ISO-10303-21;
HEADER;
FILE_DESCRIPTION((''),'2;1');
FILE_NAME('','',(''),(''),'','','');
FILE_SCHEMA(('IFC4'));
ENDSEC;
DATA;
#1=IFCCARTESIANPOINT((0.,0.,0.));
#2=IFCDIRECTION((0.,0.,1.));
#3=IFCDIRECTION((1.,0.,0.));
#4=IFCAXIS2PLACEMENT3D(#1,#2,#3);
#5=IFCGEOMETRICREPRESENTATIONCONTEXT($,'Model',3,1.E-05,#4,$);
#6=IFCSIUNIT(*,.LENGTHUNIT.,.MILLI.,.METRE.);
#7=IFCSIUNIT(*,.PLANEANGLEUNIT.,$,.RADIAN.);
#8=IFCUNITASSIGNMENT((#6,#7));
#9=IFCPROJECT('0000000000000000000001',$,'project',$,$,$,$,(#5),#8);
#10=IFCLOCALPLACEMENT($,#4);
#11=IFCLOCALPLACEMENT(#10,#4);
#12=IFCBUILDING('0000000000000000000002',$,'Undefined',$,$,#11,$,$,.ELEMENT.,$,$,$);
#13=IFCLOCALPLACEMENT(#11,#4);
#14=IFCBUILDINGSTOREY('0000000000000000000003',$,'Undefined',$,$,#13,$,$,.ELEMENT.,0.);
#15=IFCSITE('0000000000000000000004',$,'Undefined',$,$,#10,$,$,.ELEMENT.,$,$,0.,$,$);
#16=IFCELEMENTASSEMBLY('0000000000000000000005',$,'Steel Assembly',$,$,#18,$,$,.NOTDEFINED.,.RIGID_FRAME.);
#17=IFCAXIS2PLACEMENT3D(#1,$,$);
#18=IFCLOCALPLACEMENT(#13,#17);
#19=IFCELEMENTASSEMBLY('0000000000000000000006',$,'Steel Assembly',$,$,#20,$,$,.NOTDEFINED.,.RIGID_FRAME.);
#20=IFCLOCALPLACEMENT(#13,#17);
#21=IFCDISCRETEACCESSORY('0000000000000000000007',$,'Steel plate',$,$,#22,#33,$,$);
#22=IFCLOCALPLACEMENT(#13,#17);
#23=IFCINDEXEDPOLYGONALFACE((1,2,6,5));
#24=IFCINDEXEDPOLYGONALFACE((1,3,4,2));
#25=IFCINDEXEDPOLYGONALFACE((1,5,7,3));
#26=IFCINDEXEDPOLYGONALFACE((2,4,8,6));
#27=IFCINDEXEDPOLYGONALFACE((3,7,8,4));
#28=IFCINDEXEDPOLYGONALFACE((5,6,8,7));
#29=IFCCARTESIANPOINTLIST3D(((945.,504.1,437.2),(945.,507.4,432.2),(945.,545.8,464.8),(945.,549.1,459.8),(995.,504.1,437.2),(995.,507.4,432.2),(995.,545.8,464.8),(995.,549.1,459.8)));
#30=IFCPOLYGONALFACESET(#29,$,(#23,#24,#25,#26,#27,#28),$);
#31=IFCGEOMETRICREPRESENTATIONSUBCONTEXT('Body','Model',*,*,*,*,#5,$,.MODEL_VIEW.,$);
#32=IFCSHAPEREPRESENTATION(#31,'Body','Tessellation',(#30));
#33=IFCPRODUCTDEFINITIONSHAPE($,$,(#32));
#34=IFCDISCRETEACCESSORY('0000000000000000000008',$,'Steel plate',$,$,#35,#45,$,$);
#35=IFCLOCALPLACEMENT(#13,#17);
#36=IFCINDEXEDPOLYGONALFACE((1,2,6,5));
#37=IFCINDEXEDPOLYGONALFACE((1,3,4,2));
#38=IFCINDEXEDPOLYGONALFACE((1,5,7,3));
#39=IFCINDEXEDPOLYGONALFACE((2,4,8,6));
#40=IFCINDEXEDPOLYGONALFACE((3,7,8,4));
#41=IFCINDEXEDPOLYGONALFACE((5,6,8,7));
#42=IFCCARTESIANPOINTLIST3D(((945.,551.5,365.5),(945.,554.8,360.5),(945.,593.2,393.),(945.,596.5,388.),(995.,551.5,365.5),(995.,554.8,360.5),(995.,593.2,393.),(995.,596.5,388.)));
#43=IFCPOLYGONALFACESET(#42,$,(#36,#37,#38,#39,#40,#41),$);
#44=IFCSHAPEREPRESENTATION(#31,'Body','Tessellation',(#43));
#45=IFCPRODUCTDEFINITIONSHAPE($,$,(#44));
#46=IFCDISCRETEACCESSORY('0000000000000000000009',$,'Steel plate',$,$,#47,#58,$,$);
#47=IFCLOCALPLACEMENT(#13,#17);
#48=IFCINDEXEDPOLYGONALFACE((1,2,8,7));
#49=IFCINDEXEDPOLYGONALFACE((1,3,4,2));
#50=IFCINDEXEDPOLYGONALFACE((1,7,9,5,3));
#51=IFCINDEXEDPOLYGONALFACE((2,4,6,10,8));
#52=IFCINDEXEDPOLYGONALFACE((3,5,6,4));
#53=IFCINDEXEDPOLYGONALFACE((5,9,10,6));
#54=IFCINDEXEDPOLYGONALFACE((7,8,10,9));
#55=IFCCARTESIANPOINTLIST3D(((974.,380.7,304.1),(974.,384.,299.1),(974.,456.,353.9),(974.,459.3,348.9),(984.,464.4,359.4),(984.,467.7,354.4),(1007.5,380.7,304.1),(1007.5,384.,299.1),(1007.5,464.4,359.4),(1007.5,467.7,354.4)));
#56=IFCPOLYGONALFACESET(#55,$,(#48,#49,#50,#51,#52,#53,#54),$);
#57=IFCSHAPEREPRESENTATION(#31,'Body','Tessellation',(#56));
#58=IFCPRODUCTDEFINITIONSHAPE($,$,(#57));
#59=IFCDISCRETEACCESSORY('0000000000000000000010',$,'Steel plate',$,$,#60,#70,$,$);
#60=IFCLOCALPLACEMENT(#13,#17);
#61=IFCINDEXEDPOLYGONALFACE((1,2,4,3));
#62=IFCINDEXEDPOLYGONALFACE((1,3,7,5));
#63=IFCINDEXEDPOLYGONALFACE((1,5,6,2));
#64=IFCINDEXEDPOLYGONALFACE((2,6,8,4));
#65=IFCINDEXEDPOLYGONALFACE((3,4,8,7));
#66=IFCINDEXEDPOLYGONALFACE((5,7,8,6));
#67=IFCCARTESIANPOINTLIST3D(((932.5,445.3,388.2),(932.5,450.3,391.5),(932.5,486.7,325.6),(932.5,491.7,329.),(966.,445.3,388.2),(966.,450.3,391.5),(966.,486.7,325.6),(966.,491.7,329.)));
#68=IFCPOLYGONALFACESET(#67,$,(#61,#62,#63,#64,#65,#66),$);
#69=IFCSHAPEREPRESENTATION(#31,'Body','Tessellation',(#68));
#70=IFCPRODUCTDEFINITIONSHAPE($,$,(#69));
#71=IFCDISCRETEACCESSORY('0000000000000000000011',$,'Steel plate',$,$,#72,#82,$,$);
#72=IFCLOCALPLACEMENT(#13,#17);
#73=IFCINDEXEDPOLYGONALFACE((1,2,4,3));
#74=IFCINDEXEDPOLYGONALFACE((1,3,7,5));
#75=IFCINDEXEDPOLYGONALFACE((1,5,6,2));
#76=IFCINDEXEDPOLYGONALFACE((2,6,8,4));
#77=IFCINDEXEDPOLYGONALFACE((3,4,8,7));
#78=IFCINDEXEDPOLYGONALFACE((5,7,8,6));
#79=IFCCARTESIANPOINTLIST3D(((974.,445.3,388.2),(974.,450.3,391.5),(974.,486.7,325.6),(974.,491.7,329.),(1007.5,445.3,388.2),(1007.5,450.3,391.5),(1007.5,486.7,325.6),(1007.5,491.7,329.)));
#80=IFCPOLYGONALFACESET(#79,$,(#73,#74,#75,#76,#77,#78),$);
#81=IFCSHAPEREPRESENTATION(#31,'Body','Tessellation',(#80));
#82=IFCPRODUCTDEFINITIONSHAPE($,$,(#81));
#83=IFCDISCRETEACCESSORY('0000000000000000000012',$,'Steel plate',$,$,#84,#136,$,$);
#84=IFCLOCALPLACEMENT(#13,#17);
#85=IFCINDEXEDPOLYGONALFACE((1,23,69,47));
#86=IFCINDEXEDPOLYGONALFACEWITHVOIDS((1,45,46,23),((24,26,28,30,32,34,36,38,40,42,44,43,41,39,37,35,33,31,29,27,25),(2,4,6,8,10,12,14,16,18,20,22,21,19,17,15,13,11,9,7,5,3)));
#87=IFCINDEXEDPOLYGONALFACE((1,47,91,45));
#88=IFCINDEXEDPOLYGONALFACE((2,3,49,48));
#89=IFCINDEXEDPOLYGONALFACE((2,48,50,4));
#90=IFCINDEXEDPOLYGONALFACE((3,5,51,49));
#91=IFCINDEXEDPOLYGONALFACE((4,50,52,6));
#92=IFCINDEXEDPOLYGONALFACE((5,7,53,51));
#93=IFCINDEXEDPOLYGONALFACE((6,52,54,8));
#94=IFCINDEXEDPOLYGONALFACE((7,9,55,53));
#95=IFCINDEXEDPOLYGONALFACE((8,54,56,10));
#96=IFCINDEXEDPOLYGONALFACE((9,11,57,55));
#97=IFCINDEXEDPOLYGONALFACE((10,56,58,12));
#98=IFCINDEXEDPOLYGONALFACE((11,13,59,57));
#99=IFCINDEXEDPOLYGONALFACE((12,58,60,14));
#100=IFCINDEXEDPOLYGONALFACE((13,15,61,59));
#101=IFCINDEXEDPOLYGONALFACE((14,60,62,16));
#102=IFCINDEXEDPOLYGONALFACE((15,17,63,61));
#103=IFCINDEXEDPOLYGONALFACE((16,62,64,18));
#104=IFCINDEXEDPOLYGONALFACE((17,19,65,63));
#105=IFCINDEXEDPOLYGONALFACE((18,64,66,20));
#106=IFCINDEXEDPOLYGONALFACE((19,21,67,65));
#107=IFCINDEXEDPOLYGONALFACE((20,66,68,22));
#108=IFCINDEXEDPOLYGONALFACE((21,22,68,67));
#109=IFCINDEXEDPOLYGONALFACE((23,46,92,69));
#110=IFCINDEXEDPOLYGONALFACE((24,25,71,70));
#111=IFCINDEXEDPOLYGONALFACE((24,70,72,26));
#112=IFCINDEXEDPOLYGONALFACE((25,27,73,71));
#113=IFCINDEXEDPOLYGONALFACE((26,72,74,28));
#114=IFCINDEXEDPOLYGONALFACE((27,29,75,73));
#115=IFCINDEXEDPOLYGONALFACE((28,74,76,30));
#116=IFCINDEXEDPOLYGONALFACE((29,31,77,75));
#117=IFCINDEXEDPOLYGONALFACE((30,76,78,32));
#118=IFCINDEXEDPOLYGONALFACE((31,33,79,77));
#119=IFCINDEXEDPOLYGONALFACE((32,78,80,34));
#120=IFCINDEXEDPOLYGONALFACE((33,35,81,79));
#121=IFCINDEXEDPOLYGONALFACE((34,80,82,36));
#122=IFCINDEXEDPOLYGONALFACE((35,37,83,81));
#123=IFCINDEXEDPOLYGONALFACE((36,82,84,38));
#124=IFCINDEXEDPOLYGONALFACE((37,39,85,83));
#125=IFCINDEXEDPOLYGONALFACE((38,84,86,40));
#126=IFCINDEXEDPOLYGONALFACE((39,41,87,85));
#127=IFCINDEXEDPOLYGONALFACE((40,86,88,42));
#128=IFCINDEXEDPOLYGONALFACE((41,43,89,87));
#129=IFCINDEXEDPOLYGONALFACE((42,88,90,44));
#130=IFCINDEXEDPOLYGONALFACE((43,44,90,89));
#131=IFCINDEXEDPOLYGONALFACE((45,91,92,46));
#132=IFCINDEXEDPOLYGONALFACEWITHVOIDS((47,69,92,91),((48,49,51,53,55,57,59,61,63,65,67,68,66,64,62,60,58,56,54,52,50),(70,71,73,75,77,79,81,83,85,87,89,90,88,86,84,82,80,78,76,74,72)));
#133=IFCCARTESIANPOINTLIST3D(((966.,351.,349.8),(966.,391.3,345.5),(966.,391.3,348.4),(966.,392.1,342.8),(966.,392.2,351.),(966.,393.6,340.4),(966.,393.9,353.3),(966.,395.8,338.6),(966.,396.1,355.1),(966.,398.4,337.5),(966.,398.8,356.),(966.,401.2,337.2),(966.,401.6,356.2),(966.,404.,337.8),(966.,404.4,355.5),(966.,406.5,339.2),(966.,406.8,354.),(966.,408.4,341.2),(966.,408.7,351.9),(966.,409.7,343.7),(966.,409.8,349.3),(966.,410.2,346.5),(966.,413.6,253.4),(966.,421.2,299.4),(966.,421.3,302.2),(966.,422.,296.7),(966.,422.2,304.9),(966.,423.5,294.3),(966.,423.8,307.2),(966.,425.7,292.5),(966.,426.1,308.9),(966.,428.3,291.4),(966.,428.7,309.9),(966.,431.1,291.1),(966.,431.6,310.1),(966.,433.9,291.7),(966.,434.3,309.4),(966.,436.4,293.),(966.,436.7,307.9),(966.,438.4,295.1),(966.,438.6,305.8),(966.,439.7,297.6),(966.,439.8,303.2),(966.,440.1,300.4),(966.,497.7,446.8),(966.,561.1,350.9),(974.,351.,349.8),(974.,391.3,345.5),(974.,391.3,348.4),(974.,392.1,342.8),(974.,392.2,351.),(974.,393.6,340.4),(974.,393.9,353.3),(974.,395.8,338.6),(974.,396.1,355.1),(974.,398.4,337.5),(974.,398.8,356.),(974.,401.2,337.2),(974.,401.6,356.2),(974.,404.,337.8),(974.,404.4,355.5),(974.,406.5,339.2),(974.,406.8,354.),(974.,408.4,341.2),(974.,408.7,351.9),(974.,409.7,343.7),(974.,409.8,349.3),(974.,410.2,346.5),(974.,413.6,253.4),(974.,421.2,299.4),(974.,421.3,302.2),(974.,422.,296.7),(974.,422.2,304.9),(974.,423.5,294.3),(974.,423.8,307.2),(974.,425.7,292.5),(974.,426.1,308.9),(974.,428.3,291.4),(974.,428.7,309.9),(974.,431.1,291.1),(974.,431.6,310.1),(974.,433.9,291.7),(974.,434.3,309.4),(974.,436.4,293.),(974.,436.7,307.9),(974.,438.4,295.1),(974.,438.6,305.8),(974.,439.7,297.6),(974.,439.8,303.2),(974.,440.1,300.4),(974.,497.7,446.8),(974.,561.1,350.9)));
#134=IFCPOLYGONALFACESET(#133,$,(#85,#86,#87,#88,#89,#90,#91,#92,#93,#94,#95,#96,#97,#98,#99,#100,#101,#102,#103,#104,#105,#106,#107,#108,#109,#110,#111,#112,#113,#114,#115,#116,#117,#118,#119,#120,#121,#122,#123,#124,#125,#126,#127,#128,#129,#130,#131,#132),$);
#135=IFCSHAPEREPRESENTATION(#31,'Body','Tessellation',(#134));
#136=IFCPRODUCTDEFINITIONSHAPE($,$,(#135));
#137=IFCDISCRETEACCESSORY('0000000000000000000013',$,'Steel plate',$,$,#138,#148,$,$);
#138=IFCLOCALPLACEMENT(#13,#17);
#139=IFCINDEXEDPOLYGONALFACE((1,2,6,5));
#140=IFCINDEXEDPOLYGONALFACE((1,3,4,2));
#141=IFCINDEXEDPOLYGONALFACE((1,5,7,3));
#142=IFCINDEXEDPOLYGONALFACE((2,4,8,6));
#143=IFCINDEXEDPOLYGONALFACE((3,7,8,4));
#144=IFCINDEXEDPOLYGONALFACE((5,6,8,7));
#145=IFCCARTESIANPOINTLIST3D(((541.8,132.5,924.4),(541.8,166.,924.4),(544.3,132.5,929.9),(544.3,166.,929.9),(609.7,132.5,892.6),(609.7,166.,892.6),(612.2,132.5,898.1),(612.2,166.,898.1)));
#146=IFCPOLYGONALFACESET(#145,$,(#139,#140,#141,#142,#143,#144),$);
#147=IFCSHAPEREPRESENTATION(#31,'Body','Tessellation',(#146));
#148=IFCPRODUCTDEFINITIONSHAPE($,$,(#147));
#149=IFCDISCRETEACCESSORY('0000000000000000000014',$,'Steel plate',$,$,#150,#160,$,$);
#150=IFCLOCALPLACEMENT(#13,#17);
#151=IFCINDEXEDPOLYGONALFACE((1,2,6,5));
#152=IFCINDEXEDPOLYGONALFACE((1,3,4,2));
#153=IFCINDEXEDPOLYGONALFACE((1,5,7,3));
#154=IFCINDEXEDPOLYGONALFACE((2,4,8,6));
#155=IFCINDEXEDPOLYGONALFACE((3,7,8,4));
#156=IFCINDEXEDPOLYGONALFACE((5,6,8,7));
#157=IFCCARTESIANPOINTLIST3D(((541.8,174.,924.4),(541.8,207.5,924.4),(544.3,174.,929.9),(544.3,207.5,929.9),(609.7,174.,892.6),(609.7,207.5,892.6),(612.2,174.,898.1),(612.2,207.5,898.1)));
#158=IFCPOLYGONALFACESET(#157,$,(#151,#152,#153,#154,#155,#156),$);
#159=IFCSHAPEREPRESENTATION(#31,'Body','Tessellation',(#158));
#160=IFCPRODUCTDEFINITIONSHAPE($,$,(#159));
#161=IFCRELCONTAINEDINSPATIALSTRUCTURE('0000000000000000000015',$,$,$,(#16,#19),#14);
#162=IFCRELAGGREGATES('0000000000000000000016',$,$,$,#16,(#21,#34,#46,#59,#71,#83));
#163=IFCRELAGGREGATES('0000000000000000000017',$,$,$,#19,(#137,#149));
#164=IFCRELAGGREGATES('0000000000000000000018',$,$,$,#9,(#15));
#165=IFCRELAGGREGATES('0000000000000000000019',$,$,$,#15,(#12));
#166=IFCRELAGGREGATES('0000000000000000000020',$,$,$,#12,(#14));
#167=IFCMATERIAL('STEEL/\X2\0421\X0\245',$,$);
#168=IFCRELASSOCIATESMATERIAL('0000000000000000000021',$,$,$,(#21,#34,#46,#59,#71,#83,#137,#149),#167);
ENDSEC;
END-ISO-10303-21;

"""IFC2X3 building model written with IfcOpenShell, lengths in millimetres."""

from ifc_helpers import new_model, si_unit, frame, origin_with_axes, origin_2d_with_axis, place, context, subcontext, project, spatial, polyline, circle, outline, extrude, source, transform, mapped, material, element, aggregate, save


model = new_model("IFC2X3")

# Units and contexts
model_context = context("Model", 3, precision=1e-05, world=origin_with_axes())
body_context = subcontext(model_context, "Body", "Model", "MODEL_VIEW")
ifc_project = project(units=[si_unit("LENGTHUNIT", "METRE", prefix="MILLI"), si_unit("PLANEANGLEUNIT", "RADIAN")], contexts=[model_context])

# Site, building, storey
site_placement = place(None, origin_with_axes())
site = spatial("IfcSite", under=ifc_project, at=site_placement, Name="Undefined", CompositionType="ELEMENT", RefElevation=0.0)
building_placement = place(site_placement, origin_with_axes())
building = spatial("IfcBuilding", under=site, at=building_placement, Name="Undefined", CompositionType="ELEMENT")
storey_placement = place(building_placement, origin_with_axes())
storey = spatial("IfcBuildingStorey", under=building, at=storey_placement, Name="Undefined", CompositionType="ELEMENT", Elevation=0.0)

# Element assemblies
assembly_1_placement = place(storey_placement, origin_with_axes())
assembly_1 = element("IfcElementAssembly", 1, at=assembly_1_placement, inside=storey, Name="Steel Assembly", AssemblyPlace="NOTDEFINED", PredefinedType="RIGID_FRAME")
assembly_2_placement = place(storey_placement, origin_with_axes())
assembly_2 = element("IfcElementAssembly", 2, at=assembly_2_placement, inside=storey, Name="Steel Assembly", AssemblyPlace="NOTDEFINED", PredefinedType="RIGID_FRAME")

# Discrete accessories
ifc_material_1 = material(Name="STEEL/С245")
discrete_accessory_1_placement = place(assembly_1_placement, frame((995.0, 505.7, 434.7), z_axis=(0.0, -0.551387, 0.83425), x_axis=(0.0, 0.83425, 0.551387)))
discrete_accessory_1 = element("IfcDiscreteAccessory", 3, at=discrete_accessory_1_placement, material=ifc_material_1, Name="Steel plate", context=body_context, shape_type="SweptSolid", body=[
    extrude(outline(polyline([(0.0, 0.0), (50.0, 0.0), (50.0, 50.0), (0.0, 50.0), (0.0, 0.0)])), frame((0.0, 0.0, -3.0), z_axis=(0.0, 0.0, 1.0), x_axis=(1.0, 0.0, 0.0)), (0.0, 0.0, 1.0), 6.0),
])
discrete_accessory_2_placement = place(assembly_1_placement, frame((995.0, 553.1, 363.0), z_axis=(0.0, -0.551387, 0.83425), x_axis=(0.0, 0.83425, 0.551387)))
discrete_accessory_2 = element("IfcDiscreteAccessory", 4, at=discrete_accessory_2_placement, material=ifc_material_1, Name="Steel plate", context=body_context, shape_type="SweptSolid", body=[
    extrude(outline(polyline([(0.0, 0.0), (50.0, 0.0), (50.0, 50.0), (0.0, 50.0), (0.0, 0.0)])), frame((0.0, 0.0, -3.0), z_axis=(0.0, 0.0, 1.0), x_axis=(1.0, 0.0, 0.0)), (0.0, 0.0, 1.0), 6.0),
])
discrete_accessory_3_placement = place(assembly_1_placement, frame((1007.5, 382.3, 301.6), z_axis=(0.0, -0.551387, 0.83425), x_axis=(0.0, 0.83425, 0.551387)))
discrete_accessory_3 = element("IfcDiscreteAccessory", 5, at=discrete_accessory_3_placement, material=ifc_material_1, Name="Steel plate", context=body_context, shape_type="SweptSolid", body=[
    extrude(outline(polyline([(0.0, 0.0), (100.3, 0.0), (100.3, 23.5), (90.3, 33.5), (0.0, 33.5), (0.0, 0.0)])), frame((0.0, 0.0, -3.0), z_axis=(0.0, 0.0, 1.0), x_axis=(1.0, 0.0, 0.0)), (0.0, 0.0, 1.0), 6.0),
])

# Discrete accessories, openings
discrete_accessory_4_placement = place(assembly_1_placement, frame((932.5, 447.8, 389.9), z_axis=(0.0, -0.83425, -0.551387), x_axis=(0.0, 0.551387, -0.83425)))
discrete_accessory_4 = element("IfcDiscreteAccessory", 6, at=discrete_accessory_4_placement, material=ifc_material_1, Name="Steel plate", context=body_context, shape_type="SweptSolid", body=[
    extrude(outline(polyline([(0.0, 0.0), (75.0, 0.0), (75.0, 75.0), (0.0, 75.0), (0.0, 0.0)])), frame((0.0, 0.0, -3.0), z_axis=(0.0, 0.0, 1.0), x_axis=(1.0, 0.0, 0.0)), (0.0, 0.0, 1.0), 6.0),
])
opening_1_placement = place(assembly_1_placement, frame((932.5, 447.8, 389.9), z_axis=(0.0, -0.83425, -0.551387), x_axis=(0.0, 0.551387, -0.83425)))
element("IfcOpeningElement", 7, at=opening_1_placement, cuts=discrete_accessory_4, ObjectType="Recess", context=body_context, shape_type="SweptSolid", body=[
    extrude(outline(polyline([(0.0, 0.0), (75.0, 0.0), (75.0, 150.0), (0.0, 150.0), (0.0, 0.0)])), frame((112.5, 33.5, -6.0), z_axis=(0.0, 0.0, 1.0), x_axis=(0.0, 1.0, 0.0)), (0.0, 0.0, 1.0), 12.0),
])
discrete_accessory_5_placement = place(assembly_1_placement, frame((1007.5, 489.2, 327.3), z_axis=(0.0, -0.83425, -0.551387), x_axis=(0.0, -0.551387, 0.83425)))
discrete_accessory_5 = element("IfcDiscreteAccessory", 8, at=discrete_accessory_5_placement, material=ifc_material_1, Name="Steel plate", context=body_context, shape_type="SweptSolid", body=[
    extrude(outline(polyline([(0.0, 0.0), (75.0, 0.0), (75.0, 75.0), (0.0, 75.0), (0.0, 0.0)])), frame((0.0, 0.0, -3.0), z_axis=(0.0, 0.0, 1.0), x_axis=(1.0, 0.0, 0.0)), (0.0, 0.0, 1.0), 6.0),
])
opening_2_placement = place(assembly_1_placement, frame((1007.5, 489.2, 327.3), z_axis=(0.0, -0.83425, -0.551387), x_axis=(0.0, -0.551387, 0.83425)))
element("IfcOpeningElement", 9, at=opening_2_placement, cuts=discrete_accessory_5, ObjectType="Recess", context=body_context, shape_type="SweptSolid", body=[
    extrude(outline(polyline([(0.0, 0.0), (75.0, 0.0), (75.0, 150.0), (0.0, 150.0), (0.0, 0.0)])), frame((112.5, 33.5, -6.0), z_axis=(0.0, 0.0, 1.0), x_axis=(0.0, 1.0, 0.0)), (0.0, 0.0, 1.0), 12.0),
])
discrete_accessory_6_placement = place(assembly_1_placement, frame((970.0, 351.0, 349.8), z_axis=(1.0, 0.0, 0.0), x_axis=(0.0, 0.544395, -0.838829)))
discrete_accessory_6 = element("IfcDiscreteAccessory", 10, at=discrete_accessory_6_placement, material=ifc_material_1, Name="Steel plate", context=body_context, shape_type="SweptSolid", body=[
    extrude(outline(polyline([(0.0, 0.0), (115.0, 0.0), (113.5, 176.8), (-1.5, 175.9), (0.0, 0.0)])), frame((0.0, 0.0, -4.0), z_axis=(0.0, 0.0, 1.0), x_axis=(1.0, 0.0, 0.0)), (0.0, 0.0, 1.0), 8.0),
])
shared_shape_1 = source(origin_with_axes(), body_context, "Body", "SweptSolid", [
    extrude(circle(Radius=9.5, at=origin_2d_with_axis()), frame((0.0, -4.1, 0.0), z_axis=(0.0, 1.0, 0.0), x_axis=(1.0, 0.0, 0.0)), (0.0, 0.0, 1.0), 12.3),
])
opening_3_placement = place(assembly_1_placement, frame((970.0, 415.7, 323.7), z_axis=(0.0, -0.544395, 0.838829), x_axis=(0.0, 0.838829, 0.544395)))
element("IfcOpeningElement", 11, at=opening_3_placement, cuts=discrete_accessory_6, ObjectType="Opening", context=body_context, shape_type="MappedRepresentation", body=[
    mapped(shared_shape_1, transform((0.0, 0.0, -27.5))),
    mapped(shared_shape_1, transform((0.0, 0.0, 27.5))),
])
aggregate(assembly_1, [discrete_accessory_1, discrete_accessory_2, discrete_accessory_3, discrete_accessory_4, discrete_accessory_5, discrete_accessory_6])
discrete_accessory_7_placement = place(assembly_2_placement, frame((543.0, 132.5, 927.1), z_axis=(0.424008, 0.0, 0.905659), x_axis=(0.905659, 0.0, -0.424008)))
discrete_accessory_7 = element("IfcDiscreteAccessory", 12, at=discrete_accessory_7_placement, material=ifc_material_1, Name="Steel plate", context=body_context, shape_type="SweptSolid", body=[
    extrude(outline(polyline([(0.0, 0.0), (75.0, 0.0), (75.0, 75.0), (0.0, 75.0), (0.0, 0.0)])), frame((0.0, 0.0, -3.0), z_axis=(0.0, 0.0, 1.0), x_axis=(1.0, 0.0, 0.0)), (0.0, 0.0, 1.0), 6.0),
])
opening_4_placement = place(assembly_2_placement, frame((543.0, 132.5, 927.1), z_axis=(0.424008, 0.0, 0.905659), x_axis=(0.905659, 0.0, -0.424008)))
element("IfcOpeningElement", 13, at=opening_4_placement, cuts=discrete_accessory_7, ObjectType="Recess", context=body_context, shape_type="SweptSolid", body=[
    extrude(outline(polyline([(0.0, 0.0), (75.0, 0.0), (75.0, 150.0), (0.0, 150.0), (0.0, 0.0)])), frame((112.5, 108.5, 6.0), z_axis=(0.0, 0.0, -1.0), x_axis=(0.0, -1.0, 0.0)), (0.0, 0.0, 1.0), 12.0),
])
discrete_accessory_8_placement = place(assembly_2_placement, frame((611.0, 207.5, 895.3), z_axis=(0.424008, 0.0, 0.905659), x_axis=(-0.905659, 0.0, 0.424008)))
discrete_accessory_8 = element("IfcDiscreteAccessory", 14, at=discrete_accessory_8_placement, material=ifc_material_1, Name="Steel plate", context=body_context, shape_type="SweptSolid", body=[
    extrude(outline(polyline([(0.0, 0.0), (75.0, 0.0), (75.0, 75.0), (0.0, 75.0), (0.0, 0.0)])), frame((0.0, 0.0, -3.0), z_axis=(0.0, 0.0, 1.0), x_axis=(1.0, 0.0, 0.0)), (0.0, 0.0, 1.0), 6.0),
])
opening_5_placement = place(assembly_2_placement, frame((611.0, 207.5, 895.3), z_axis=(0.424008, 0.0, 0.905659), x_axis=(-0.905659, 0.0, 0.424008)))
element("IfcOpeningElement", 15, at=opening_5_placement, cuts=discrete_accessory_8, ObjectType="Recess", context=body_context, shape_type="SweptSolid", body=[
    extrude(outline(polyline([(0.0, 0.0), (75.0, 0.0), (75.0, 150.0), (0.0, 150.0), (0.0, 0.0)])), frame((112.5, 108.5, 6.0), z_axis=(0.0, 0.0, -1.0), x_axis=(0.0, -1.0, 0.0)), (0.0, 0.0, 1.0), 12.0),
])

aggregate(assembly_2, [discrete_accessory_7, discrete_accessory_8])

save(model, "model.ifc")
